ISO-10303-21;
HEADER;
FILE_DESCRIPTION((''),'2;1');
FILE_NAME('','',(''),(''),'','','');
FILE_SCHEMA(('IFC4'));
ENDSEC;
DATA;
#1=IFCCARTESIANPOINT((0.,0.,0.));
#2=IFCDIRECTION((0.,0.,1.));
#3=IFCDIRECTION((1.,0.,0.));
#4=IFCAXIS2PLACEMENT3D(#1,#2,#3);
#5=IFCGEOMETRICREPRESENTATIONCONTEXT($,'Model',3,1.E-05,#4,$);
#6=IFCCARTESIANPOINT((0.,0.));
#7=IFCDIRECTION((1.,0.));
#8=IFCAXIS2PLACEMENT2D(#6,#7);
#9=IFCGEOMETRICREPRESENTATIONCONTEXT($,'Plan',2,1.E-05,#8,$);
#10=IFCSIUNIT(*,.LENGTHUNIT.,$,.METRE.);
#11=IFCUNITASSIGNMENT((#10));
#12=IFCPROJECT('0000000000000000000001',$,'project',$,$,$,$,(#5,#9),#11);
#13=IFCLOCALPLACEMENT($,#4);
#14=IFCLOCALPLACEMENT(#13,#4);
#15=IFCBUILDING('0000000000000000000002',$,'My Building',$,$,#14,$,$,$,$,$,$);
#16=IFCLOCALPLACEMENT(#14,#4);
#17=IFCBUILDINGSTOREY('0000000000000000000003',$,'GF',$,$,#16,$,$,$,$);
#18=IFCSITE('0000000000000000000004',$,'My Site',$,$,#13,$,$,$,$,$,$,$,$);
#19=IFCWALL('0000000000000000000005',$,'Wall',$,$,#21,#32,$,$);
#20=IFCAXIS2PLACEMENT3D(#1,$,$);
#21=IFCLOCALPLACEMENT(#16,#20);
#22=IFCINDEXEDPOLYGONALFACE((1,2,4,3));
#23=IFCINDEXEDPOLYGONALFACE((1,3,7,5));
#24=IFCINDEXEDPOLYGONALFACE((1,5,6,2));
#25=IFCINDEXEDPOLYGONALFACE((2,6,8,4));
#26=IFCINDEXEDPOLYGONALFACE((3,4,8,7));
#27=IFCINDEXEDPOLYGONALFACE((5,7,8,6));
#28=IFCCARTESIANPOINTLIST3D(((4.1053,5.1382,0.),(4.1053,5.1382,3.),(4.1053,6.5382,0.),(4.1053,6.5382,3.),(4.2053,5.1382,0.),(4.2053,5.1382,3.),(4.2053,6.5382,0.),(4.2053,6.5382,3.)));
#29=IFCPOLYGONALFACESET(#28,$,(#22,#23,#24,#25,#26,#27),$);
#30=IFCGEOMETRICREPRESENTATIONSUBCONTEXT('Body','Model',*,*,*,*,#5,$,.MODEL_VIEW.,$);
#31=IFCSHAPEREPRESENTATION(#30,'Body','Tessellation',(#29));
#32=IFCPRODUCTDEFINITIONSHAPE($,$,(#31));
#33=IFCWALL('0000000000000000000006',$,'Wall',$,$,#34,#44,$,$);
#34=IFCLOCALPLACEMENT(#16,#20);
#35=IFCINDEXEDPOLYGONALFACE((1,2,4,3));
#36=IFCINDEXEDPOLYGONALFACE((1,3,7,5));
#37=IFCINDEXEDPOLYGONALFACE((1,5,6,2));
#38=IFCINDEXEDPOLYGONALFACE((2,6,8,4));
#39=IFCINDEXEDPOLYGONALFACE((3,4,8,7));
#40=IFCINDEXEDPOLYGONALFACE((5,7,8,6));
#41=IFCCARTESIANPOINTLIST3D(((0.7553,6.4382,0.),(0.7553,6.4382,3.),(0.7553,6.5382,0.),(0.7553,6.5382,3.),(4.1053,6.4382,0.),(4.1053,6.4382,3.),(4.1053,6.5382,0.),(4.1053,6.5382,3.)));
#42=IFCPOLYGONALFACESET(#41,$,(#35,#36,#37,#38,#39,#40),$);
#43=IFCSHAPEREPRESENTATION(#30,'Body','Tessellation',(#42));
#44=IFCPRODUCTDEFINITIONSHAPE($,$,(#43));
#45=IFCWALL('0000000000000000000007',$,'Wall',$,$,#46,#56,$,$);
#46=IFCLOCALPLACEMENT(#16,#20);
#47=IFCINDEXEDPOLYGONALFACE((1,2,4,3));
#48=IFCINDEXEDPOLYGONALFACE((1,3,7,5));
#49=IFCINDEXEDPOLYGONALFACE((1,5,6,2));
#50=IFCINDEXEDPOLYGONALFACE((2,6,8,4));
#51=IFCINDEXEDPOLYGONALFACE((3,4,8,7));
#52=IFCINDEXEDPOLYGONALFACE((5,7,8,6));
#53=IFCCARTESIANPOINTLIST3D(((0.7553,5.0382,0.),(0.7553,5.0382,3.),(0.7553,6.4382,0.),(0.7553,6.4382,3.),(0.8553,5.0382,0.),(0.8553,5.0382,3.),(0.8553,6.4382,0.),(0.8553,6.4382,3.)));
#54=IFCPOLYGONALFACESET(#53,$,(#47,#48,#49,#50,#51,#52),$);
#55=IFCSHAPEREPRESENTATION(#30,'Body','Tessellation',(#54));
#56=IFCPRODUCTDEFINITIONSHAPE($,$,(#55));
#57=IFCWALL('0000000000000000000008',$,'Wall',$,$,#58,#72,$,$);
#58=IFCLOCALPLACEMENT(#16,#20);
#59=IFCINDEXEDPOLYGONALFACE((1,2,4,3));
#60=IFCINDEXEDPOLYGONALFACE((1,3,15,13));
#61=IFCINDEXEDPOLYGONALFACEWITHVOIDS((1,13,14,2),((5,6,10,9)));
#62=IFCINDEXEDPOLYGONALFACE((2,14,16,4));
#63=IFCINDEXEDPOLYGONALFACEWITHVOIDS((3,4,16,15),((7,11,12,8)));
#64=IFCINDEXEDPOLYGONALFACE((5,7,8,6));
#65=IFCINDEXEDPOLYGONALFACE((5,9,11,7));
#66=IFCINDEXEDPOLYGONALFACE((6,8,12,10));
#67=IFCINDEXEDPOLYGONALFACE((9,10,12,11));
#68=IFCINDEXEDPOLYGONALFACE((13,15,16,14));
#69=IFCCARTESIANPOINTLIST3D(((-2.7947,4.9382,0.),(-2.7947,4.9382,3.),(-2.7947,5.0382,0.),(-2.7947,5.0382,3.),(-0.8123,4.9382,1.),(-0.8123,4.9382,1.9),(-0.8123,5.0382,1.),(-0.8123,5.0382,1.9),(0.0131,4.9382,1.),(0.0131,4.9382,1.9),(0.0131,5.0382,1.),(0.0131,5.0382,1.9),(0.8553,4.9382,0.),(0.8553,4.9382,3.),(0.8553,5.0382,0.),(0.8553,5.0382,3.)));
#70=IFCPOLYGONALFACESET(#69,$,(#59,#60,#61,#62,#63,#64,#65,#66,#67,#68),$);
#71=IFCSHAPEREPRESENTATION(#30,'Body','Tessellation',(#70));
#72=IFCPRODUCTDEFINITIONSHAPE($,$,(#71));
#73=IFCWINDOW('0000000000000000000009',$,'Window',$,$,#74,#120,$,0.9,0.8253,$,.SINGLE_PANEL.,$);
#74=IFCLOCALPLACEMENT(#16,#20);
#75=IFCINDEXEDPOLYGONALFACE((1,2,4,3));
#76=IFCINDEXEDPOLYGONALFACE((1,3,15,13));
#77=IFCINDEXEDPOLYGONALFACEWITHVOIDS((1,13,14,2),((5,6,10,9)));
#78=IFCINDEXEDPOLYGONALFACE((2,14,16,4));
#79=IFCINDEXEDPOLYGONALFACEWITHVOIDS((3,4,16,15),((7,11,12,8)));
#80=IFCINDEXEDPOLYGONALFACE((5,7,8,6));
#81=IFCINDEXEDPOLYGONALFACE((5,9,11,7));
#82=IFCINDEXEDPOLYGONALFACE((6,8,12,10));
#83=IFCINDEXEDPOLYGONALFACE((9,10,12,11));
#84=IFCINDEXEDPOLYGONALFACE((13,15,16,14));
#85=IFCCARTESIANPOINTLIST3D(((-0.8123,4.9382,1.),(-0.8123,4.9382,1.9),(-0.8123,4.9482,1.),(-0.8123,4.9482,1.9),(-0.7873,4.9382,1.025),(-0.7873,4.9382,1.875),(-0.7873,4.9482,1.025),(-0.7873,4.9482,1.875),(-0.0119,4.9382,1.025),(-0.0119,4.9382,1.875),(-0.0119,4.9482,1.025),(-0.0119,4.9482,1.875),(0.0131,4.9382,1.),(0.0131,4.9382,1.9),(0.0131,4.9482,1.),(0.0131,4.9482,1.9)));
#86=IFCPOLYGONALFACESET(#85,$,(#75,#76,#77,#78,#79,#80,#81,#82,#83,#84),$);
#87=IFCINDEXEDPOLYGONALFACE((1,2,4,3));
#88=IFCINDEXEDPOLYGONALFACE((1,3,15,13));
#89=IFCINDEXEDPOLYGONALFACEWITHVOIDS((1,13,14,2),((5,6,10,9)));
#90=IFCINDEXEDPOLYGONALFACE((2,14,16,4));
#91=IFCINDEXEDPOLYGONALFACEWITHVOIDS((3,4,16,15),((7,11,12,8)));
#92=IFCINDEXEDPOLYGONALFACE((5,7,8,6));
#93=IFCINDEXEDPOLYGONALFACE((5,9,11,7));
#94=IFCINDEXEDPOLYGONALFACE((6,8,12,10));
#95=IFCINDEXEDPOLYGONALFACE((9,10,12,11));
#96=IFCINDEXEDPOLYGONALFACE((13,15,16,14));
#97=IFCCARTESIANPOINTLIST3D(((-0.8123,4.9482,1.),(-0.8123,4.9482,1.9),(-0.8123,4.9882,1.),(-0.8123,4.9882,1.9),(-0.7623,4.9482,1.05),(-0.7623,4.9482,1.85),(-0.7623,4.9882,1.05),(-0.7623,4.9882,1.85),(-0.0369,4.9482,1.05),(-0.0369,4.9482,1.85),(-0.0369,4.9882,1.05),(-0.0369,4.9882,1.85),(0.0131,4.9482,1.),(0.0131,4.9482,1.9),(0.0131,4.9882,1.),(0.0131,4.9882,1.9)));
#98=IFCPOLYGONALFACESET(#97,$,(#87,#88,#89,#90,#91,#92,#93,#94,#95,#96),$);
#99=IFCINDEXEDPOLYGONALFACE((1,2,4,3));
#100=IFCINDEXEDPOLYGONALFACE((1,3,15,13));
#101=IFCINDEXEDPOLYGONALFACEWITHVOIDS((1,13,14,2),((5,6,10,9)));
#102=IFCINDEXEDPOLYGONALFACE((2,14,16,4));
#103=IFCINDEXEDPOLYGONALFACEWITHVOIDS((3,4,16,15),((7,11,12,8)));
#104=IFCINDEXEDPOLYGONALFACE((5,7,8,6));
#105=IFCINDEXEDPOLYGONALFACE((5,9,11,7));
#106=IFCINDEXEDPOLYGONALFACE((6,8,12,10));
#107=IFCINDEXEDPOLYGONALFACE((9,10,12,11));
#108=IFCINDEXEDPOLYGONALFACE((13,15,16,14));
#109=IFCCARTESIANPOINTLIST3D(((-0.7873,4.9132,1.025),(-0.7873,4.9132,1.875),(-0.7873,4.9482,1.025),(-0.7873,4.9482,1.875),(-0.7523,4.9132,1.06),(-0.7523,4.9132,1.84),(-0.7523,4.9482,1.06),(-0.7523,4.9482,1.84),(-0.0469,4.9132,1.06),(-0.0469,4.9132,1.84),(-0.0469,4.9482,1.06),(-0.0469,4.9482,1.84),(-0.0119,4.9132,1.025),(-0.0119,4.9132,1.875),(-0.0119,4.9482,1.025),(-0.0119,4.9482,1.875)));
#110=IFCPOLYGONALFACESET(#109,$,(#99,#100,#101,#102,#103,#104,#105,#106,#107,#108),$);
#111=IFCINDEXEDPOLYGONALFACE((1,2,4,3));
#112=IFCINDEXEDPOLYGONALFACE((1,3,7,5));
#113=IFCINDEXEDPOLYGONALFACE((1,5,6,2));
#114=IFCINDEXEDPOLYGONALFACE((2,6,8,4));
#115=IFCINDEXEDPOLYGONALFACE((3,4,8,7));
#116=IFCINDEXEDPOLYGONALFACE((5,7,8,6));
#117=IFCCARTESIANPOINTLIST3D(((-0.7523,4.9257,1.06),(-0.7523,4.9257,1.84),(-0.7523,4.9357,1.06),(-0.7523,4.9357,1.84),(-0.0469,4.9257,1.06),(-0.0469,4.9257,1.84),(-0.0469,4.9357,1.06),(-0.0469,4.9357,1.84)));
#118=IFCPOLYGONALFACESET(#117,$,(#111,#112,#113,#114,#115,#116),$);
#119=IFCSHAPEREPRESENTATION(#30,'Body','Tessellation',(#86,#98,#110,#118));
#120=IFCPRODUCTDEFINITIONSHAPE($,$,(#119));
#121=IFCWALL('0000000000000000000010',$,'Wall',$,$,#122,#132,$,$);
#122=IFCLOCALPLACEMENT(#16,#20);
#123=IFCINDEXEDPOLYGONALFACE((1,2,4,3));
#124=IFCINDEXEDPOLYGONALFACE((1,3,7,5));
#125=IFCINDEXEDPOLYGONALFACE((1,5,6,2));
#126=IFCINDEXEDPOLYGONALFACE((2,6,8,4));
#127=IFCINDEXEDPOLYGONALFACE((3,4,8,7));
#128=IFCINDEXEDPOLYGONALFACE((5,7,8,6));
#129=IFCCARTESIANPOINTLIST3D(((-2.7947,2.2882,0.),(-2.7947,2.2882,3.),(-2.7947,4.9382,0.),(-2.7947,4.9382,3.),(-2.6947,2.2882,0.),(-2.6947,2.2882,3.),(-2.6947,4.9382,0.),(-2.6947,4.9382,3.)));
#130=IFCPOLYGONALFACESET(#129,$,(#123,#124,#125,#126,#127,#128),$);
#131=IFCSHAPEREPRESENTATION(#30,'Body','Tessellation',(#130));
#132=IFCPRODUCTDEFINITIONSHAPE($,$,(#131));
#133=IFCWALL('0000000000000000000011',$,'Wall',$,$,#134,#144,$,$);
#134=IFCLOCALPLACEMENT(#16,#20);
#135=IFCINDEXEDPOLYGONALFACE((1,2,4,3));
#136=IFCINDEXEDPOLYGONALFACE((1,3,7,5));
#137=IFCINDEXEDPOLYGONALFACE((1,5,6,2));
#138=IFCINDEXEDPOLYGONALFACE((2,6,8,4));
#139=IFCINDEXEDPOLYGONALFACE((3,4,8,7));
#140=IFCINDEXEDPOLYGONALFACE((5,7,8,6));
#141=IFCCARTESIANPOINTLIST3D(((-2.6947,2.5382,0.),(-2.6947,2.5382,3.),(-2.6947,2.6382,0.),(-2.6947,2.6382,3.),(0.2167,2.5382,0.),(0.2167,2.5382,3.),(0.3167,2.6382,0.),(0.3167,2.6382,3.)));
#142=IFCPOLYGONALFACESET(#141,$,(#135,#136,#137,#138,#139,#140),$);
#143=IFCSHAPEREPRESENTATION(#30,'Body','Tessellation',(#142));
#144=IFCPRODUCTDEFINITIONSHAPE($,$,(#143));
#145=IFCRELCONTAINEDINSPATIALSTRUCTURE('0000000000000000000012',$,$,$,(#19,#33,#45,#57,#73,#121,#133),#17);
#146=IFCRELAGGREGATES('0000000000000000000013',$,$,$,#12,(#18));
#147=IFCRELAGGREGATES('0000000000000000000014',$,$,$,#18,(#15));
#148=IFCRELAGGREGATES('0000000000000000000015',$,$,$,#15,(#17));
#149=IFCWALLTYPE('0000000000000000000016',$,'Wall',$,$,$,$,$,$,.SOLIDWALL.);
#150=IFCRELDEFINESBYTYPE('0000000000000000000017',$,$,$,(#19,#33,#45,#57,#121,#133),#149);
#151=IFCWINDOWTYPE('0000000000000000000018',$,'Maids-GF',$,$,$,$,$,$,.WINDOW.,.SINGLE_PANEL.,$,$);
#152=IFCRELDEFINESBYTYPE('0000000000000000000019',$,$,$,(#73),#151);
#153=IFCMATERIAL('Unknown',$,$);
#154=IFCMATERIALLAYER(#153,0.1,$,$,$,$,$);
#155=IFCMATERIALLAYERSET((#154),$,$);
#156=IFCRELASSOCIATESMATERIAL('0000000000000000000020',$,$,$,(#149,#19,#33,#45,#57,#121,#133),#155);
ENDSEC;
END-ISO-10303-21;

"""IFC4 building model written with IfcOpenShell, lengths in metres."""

from ifc_helpers import new_model, entity, si_unit, frame, origin_with_axes, origin_2d_with_axis, place, context, subcontext, project, spatial, line, indexed_curve, outline, extrude, shape, source, transform, mapped, material, layer, layer_set, layer_usage, type_object, type_shapes, element, fill, save


model = new_model("IFC4")

# Units and contexts
model_context = context("Model", 3, precision=1e-05, world=origin_with_axes())
plan_context = context("Plan", 2, precision=1e-05, world=origin_2d_with_axis())
body_context_1 = subcontext(model_context, "Body", "Model", "MODEL_VIEW")
body_context_2 = subcontext(plan_context, "Body", "Plan", "PLAN_VIEW")
ifc_project = project(units=[si_unit("LENGTHUNIT", "METRE")], contexts=[model_context, plan_context])

# Site, building, storey
site_placement = place(None, origin_with_axes())
site = spatial("IfcSite", under=ifc_project, at=site_placement, Name="My Site")
building_placement = place(site_placement, origin_with_axes())
building = spatial("IfcBuilding", under=site, at=building_placement, Name="My Building")
storey_placement = place(building_placement, origin_with_axes())
storey = spatial("IfcBuildingStorey", under=building, at=storey_placement, Name="GF")

# Shared definitions
ifc_material_1 = material(Name="Unknown")

# Walls
ifc_layer_1 = layer(ifc_material_1, 0.1)
ifc_layer_set_1 = layer_set([ifc_layer_1])
wall_type = type_object("IfcWallType", Name="Wall", PredefinedType="SOLIDWALL", material=ifc_layer_set_1)
ifc_layer_usage_1 = layer_usage(ifc_layer_set_1, "AXIS2", "POSITIVE", 0.0)
wall_1_placement = place(storey_placement, frame((4.2053, 5.1382, 0.0), z_axis=(0.0, 0.0, 1.0), x_axis=(0.0, 1.0, 0.0)))
element("IfcWall", 1, at=wall_1_placement, inside=storey, type_object=wall_type, material=ifc_layer_usage_1, Name="Wall", context=body_context_1, shape_type="SweptSolid", body=[
    extrude(outline(indexed_curve([(0.0, 0.0), (0.0, 0.1), (1.4, 0.1), (1.4, 0.0)], segments=[line(1, 2, 3, 4, 1)])), origin_with_axes(), (0.0, 0.0, 1.0), 3.0),
])
ifc_layer_usage_2 = layer_usage(ifc_layer_set_1, "AXIS2", "POSITIVE", 0.0)
wall_2_placement = place(storey_placement, frame((4.1053, 6.5382, 0.0), z_axis=(0.0, 0.0, 1.0), x_axis=(-1.0, 0.0, 0.0)))
element("IfcWall", 2, at=wall_2_placement, inside=storey, type_object=wall_type, material=ifc_layer_usage_2, Name="Wall", context=body_context_1, shape_type="SweptSolid", body=[
    extrude(outline(indexed_curve([(0.0, 0.0), (0.0, 0.1), (3.35, 0.1), (3.35, 0.0)], segments=[line(1, 2, 3, 4, 1)])), origin_with_axes(), (0.0, 0.0, 1.0), 3.0),
])
ifc_layer_usage_3 = layer_usage(ifc_layer_set_1, "AXIS2", "POSITIVE", 0.0)
wall_3_placement = place(storey_placement, frame((0.7553, 6.4382, 0.0), z_axis=(0.0, 0.0, 1.0), x_axis=(0.0, -1.0, 0.0)))
element("IfcWall", 3, at=wall_3_placement, inside=storey, type_object=wall_type, material=ifc_layer_usage_3, Name="Wall", context=body_context_1, shape_type="SweptSolid", body=[
    extrude(outline(indexed_curve([(0.0, 0.0), (0.0, 0.1), (1.4, 0.1), (1.4, 0.0)], segments=[line(1, 2, 3, 4, 1)])), origin_with_axes(), (0.0, 0.0, 1.0), 3.0),
])

# Wall, opening, window
ifc_layer_usage_4 = layer_usage(ifc_layer_set_1, "AXIS2", "POSITIVE", 0.0)
wall_4_placement = place(storey_placement, frame((0.8553, 5.0382, 0.0), z_axis=(0.0, 0.0, 1.0), x_axis=(-1.0, 0.0, 0.0)))
wall_4 = element("IfcWall", 4, at=wall_4_placement, inside=storey, type_object=wall_type, material=ifc_layer_usage_4, Name="Wall", context=body_context_1, shape_type="SweptSolid", body=[
    extrude(outline(indexed_curve([(0.0, 0.0), (0.0, 0.1), (3.65, 0.1), (3.65, 0.0)], segments=[line(1, 2, 3, 4, 1)])), origin_with_axes(), (0.0, 0.0, 1.0), 3.0),
])
shared_shape_1 = source(origin_with_axes(), body_context_1, "Body", "SweptSolid", [
    extrude(outline(indexed_curve([(0.0, 0.0), (0.8253, 0.0), (0.8253, 0.9), (0.0, 0.9)], segments=[line(1, 2, 3, 4, 1)])), frame((0.0, -0.6, 0.0), z_axis=(0.0, -1.0, 0.0), x_axis=(1.0, 0.0, 0.0)), (0.0, 0.0, -1.0), 1.2),
])
opening_1_placement = place(wall_4_placement, frame((0.8422, 0.0, 1.0), z_axis=(0.0, 0.0, 1.0), x_axis=(1.0, -0.000001, 0.0)))
opening_1 = element("IfcOpeningElement", 5, at=opening_1_placement, cuts=wall_4, PredefinedType="OPENING", context=body_context_1, shape_type="MappedRepresentation", body=[
    mapped(shared_shape_1, transform((0.0, 0.0, 0.0), x_axis=(1.0, 0.0, 0.0), y_axis=(0.0, 1.0, 0.0), z_axis=(0.0, 0.0, 1.0), scale=1.0)),
])
window_type = type_object("IfcWindowType", Name="Maids-GF", PartitioningType="SINGLE_PANEL", PredefinedType="WINDOW")
shared_shape_2 = source(origin_with_axes(), body_context_1, "Body", "SweptSolid", [
    extrude(outline(indexed_curve([(0.0, 0.0), (0.8253, 0.0), (0.8253, 0.9), (0.0, 0.9)], segments=[line(1, 2, 3, 4, 1)]), holes=[indexed_curve([(0.025, 0.025), (0.8003, 0.025), (0.8003, 0.875), (0.025, 0.875)], segments=[line(1, 2, 3, 4, 1)])]), frame((0.0, 0.09, 0.0), z_axis=(0.0, -1.0, 0.0), x_axis=(1.0, 0.0, 0.0)), (0.0, 0.0, -1.0), 0.01),
    extrude(outline(indexed_curve([(0.0, 0.0), (0.8253, 0.0), (0.8253, 0.9), (0.0, 0.9)], segments=[line(1, 2, 3, 4, 1)]), holes=[indexed_curve([(0.05, 0.05), (0.7753, 0.05), (0.7753, 0.85), (0.05, 0.85)], segments=[line(1, 2, 3, 4, 1)])]), frame((0.0, 0.05, 0.0), z_axis=(0.0, -1.0, 0.0), x_axis=(1.0, 0.0, 0.0)), (0.0, 0.0, -1.0), 0.04),
    extrude(outline(indexed_curve([(0.0, 0.0), (0.7753, 0.0), (0.7753, 0.85), (0.0, 0.85)], segments=[line(1, 2, 3, 4, 1)]), holes=[indexed_curve([(0.035, 0.035), (0.7403, 0.035), (0.7403, 0.815), (0.035, 0.815)], segments=[line(1, 2, 3, 4, 1)])]), frame((0.025, 0.09, 0.025), z_axis=(0.0, -1.0, 0.0), x_axis=(1.0, 0.0, 0.0)), (0.0, 0.0, -1.0), 0.035),
    extrude(outline(indexed_curve([(0.035, 0.035), (0.7403, 0.035), (0.7403, 0.815), (0.035, 0.815)], segments=[line(1, 2, 3, 4, 1)])), frame((0.025, 0.1025, 0.025), z_axis=(0.0, -1.0, 0.0), x_axis=(1.0, 0.0, 0.0)), (0.0, 0.0, -1.0), 0.01),
])
shared_shape_3 = source(origin_with_axes(), body_context_2, "Body", "Curve2D", [
    entity("IfcIndexedPolyCurve", entity("IfcCartesianPointList2D", [[0.05, 0.05], [0.7753, 0.05]])),
    entity("IfcIndexedPolyCurve", entity("IfcCartesianPointList2D", [[0.0, 0.1], [0.025, 0.1], [0.025, 0.09], [0.05, 0.09], [0.05, 0.05], [0.0, 0.05]]), [entity("IfcLineIndex", [1, 2, 3, 4, 5, 6, 1])]),
    entity("IfcIndexedPolyCurve", entity("IfcCartesianPointList2D", [[0.8253, 0.1], [0.8003, 0.1], [0.8003, 0.09], [0.7753, 0.09], [0.7753, 0.05], [0.8253, 0.05]]), [entity("IfcLineIndex", [1, 2, 3, 4, 5, 6, 1])]),
    entity("IfcIndexedPolyCurve", entity("IfcCartesianPointList2D", [[0.025, 0.09], [0.06, 0.09], [0.06, 0.125], [0.025, 0.125]]), [entity("IfcLineIndex", [1, 2, 3, 4, 1])]),
    entity("IfcIndexedPolyCurve", entity("IfcCartesianPointList2D", [[0.8003, 0.09], [0.7653, 0.09], [0.7653, 0.125], [0.8003, 0.125]]), [entity("IfcLineIndex", [1, 2, 3, 4, 1])]),
    entity("IfcIndexedPolyCurve", entity("IfcCartesianPointList2D", [[0.06, 0.09], [0.7653, 0.09]])),
    entity("IfcIndexedPolyCurve", entity("IfcCartesianPointList2D", [[0.06, 0.125], [0.7653, 0.125]])),
    entity("IfcIndexedPolyCurve", entity("IfcCartesianPointList2D", [[0.06, 0.1075], [0.7653, 0.1075]])),
])
type_shapes(window_type, [shared_shape_2, shared_shape_3])
window_placement = place(opening_1_placement, frame((0.0, 0.0, 0.0), z_axis=(0.0, 0.0, 1.0), x_axis=(1.0, 0.0, 0.0)))
window = element("IfcWindow", 6, at=window_placement, inside=storey, type_object=window_type, Name="Window", OverallHeight=0.9, OverallWidth=0.8253, PartitioningType="SINGLE_PANEL", shapes=[
    shape(body_context_1, "Body", "MappedRepresentation", [mapped(shared_shape_2, transform((0.0, 0.0, 0.0), x_axis=(1.0, 0.0, 0.0), y_axis=(0.0, 1.0, 0.0), z_axis=(0.0, 0.0, 1.0), scale=1.0))]),
    shape(body_context_2, "Body", "MappedRepresentation", [mapped(shared_shape_3, transform((0.0, 0.0, 0.0), x_axis=(1.0, 0.0, 0.0), y_axis=(0.0, 1.0, 0.0), z_axis=(0.0, 0.0, 1.0), scale=1.0))]),
])
fill(opening_1, window)

# Walls
ifc_layer_usage_5 = layer_usage(ifc_layer_set_1, "AXIS2", "POSITIVE", 0.0)
wall_5_placement = place(storey_placement, frame((-2.7947, 4.9382, 0.0), z_axis=(0.0, 0.0, 1.0), x_axis=(0.0, -1.0, 0.0)))
element("IfcWall", 7, at=wall_5_placement, inside=storey, type_object=wall_type, material=ifc_layer_usage_5, Name="Wall", context=body_context_1, shape_type="SweptSolid", body=[
    extrude(outline(indexed_curve([(0.0, 0.0), (0.0, 0.1), (2.65, 0.1), (2.65, 0.0)], segments=[line(1, 2, 3, 4, 1)])), origin_with_axes(), (0.0, 0.0, 1.0), 3.0),
])
ifc_layer_usage_6 = layer_usage(ifc_layer_set_1, "AXIS2", "POSITIVE", 0.0)
wall_6_placement = place(storey_placement, frame((0.3167, 2.6382, 0.0), z_axis=(0.0, 0.0, 1.0), x_axis=(-1.0, 0.0, 0.0)))
element("IfcWall", 8, at=wall_6_placement, inside=storey, type_object=wall_type, material=ifc_layer_usage_6, Name="Wall", context=body_context_1, shape_type="SweptSolid", body=[
    extrude(outline(indexed_curve([(0.0, 0.0), (0.1, 0.1), (3.0114, 0.1), (3.0114, 0.0)], segments=[line(1, 2, 3, 4, 1)])), origin_with_axes(), (0.0, 0.0, 1.0), 3.0),
])

save(model, "model.ifc")
